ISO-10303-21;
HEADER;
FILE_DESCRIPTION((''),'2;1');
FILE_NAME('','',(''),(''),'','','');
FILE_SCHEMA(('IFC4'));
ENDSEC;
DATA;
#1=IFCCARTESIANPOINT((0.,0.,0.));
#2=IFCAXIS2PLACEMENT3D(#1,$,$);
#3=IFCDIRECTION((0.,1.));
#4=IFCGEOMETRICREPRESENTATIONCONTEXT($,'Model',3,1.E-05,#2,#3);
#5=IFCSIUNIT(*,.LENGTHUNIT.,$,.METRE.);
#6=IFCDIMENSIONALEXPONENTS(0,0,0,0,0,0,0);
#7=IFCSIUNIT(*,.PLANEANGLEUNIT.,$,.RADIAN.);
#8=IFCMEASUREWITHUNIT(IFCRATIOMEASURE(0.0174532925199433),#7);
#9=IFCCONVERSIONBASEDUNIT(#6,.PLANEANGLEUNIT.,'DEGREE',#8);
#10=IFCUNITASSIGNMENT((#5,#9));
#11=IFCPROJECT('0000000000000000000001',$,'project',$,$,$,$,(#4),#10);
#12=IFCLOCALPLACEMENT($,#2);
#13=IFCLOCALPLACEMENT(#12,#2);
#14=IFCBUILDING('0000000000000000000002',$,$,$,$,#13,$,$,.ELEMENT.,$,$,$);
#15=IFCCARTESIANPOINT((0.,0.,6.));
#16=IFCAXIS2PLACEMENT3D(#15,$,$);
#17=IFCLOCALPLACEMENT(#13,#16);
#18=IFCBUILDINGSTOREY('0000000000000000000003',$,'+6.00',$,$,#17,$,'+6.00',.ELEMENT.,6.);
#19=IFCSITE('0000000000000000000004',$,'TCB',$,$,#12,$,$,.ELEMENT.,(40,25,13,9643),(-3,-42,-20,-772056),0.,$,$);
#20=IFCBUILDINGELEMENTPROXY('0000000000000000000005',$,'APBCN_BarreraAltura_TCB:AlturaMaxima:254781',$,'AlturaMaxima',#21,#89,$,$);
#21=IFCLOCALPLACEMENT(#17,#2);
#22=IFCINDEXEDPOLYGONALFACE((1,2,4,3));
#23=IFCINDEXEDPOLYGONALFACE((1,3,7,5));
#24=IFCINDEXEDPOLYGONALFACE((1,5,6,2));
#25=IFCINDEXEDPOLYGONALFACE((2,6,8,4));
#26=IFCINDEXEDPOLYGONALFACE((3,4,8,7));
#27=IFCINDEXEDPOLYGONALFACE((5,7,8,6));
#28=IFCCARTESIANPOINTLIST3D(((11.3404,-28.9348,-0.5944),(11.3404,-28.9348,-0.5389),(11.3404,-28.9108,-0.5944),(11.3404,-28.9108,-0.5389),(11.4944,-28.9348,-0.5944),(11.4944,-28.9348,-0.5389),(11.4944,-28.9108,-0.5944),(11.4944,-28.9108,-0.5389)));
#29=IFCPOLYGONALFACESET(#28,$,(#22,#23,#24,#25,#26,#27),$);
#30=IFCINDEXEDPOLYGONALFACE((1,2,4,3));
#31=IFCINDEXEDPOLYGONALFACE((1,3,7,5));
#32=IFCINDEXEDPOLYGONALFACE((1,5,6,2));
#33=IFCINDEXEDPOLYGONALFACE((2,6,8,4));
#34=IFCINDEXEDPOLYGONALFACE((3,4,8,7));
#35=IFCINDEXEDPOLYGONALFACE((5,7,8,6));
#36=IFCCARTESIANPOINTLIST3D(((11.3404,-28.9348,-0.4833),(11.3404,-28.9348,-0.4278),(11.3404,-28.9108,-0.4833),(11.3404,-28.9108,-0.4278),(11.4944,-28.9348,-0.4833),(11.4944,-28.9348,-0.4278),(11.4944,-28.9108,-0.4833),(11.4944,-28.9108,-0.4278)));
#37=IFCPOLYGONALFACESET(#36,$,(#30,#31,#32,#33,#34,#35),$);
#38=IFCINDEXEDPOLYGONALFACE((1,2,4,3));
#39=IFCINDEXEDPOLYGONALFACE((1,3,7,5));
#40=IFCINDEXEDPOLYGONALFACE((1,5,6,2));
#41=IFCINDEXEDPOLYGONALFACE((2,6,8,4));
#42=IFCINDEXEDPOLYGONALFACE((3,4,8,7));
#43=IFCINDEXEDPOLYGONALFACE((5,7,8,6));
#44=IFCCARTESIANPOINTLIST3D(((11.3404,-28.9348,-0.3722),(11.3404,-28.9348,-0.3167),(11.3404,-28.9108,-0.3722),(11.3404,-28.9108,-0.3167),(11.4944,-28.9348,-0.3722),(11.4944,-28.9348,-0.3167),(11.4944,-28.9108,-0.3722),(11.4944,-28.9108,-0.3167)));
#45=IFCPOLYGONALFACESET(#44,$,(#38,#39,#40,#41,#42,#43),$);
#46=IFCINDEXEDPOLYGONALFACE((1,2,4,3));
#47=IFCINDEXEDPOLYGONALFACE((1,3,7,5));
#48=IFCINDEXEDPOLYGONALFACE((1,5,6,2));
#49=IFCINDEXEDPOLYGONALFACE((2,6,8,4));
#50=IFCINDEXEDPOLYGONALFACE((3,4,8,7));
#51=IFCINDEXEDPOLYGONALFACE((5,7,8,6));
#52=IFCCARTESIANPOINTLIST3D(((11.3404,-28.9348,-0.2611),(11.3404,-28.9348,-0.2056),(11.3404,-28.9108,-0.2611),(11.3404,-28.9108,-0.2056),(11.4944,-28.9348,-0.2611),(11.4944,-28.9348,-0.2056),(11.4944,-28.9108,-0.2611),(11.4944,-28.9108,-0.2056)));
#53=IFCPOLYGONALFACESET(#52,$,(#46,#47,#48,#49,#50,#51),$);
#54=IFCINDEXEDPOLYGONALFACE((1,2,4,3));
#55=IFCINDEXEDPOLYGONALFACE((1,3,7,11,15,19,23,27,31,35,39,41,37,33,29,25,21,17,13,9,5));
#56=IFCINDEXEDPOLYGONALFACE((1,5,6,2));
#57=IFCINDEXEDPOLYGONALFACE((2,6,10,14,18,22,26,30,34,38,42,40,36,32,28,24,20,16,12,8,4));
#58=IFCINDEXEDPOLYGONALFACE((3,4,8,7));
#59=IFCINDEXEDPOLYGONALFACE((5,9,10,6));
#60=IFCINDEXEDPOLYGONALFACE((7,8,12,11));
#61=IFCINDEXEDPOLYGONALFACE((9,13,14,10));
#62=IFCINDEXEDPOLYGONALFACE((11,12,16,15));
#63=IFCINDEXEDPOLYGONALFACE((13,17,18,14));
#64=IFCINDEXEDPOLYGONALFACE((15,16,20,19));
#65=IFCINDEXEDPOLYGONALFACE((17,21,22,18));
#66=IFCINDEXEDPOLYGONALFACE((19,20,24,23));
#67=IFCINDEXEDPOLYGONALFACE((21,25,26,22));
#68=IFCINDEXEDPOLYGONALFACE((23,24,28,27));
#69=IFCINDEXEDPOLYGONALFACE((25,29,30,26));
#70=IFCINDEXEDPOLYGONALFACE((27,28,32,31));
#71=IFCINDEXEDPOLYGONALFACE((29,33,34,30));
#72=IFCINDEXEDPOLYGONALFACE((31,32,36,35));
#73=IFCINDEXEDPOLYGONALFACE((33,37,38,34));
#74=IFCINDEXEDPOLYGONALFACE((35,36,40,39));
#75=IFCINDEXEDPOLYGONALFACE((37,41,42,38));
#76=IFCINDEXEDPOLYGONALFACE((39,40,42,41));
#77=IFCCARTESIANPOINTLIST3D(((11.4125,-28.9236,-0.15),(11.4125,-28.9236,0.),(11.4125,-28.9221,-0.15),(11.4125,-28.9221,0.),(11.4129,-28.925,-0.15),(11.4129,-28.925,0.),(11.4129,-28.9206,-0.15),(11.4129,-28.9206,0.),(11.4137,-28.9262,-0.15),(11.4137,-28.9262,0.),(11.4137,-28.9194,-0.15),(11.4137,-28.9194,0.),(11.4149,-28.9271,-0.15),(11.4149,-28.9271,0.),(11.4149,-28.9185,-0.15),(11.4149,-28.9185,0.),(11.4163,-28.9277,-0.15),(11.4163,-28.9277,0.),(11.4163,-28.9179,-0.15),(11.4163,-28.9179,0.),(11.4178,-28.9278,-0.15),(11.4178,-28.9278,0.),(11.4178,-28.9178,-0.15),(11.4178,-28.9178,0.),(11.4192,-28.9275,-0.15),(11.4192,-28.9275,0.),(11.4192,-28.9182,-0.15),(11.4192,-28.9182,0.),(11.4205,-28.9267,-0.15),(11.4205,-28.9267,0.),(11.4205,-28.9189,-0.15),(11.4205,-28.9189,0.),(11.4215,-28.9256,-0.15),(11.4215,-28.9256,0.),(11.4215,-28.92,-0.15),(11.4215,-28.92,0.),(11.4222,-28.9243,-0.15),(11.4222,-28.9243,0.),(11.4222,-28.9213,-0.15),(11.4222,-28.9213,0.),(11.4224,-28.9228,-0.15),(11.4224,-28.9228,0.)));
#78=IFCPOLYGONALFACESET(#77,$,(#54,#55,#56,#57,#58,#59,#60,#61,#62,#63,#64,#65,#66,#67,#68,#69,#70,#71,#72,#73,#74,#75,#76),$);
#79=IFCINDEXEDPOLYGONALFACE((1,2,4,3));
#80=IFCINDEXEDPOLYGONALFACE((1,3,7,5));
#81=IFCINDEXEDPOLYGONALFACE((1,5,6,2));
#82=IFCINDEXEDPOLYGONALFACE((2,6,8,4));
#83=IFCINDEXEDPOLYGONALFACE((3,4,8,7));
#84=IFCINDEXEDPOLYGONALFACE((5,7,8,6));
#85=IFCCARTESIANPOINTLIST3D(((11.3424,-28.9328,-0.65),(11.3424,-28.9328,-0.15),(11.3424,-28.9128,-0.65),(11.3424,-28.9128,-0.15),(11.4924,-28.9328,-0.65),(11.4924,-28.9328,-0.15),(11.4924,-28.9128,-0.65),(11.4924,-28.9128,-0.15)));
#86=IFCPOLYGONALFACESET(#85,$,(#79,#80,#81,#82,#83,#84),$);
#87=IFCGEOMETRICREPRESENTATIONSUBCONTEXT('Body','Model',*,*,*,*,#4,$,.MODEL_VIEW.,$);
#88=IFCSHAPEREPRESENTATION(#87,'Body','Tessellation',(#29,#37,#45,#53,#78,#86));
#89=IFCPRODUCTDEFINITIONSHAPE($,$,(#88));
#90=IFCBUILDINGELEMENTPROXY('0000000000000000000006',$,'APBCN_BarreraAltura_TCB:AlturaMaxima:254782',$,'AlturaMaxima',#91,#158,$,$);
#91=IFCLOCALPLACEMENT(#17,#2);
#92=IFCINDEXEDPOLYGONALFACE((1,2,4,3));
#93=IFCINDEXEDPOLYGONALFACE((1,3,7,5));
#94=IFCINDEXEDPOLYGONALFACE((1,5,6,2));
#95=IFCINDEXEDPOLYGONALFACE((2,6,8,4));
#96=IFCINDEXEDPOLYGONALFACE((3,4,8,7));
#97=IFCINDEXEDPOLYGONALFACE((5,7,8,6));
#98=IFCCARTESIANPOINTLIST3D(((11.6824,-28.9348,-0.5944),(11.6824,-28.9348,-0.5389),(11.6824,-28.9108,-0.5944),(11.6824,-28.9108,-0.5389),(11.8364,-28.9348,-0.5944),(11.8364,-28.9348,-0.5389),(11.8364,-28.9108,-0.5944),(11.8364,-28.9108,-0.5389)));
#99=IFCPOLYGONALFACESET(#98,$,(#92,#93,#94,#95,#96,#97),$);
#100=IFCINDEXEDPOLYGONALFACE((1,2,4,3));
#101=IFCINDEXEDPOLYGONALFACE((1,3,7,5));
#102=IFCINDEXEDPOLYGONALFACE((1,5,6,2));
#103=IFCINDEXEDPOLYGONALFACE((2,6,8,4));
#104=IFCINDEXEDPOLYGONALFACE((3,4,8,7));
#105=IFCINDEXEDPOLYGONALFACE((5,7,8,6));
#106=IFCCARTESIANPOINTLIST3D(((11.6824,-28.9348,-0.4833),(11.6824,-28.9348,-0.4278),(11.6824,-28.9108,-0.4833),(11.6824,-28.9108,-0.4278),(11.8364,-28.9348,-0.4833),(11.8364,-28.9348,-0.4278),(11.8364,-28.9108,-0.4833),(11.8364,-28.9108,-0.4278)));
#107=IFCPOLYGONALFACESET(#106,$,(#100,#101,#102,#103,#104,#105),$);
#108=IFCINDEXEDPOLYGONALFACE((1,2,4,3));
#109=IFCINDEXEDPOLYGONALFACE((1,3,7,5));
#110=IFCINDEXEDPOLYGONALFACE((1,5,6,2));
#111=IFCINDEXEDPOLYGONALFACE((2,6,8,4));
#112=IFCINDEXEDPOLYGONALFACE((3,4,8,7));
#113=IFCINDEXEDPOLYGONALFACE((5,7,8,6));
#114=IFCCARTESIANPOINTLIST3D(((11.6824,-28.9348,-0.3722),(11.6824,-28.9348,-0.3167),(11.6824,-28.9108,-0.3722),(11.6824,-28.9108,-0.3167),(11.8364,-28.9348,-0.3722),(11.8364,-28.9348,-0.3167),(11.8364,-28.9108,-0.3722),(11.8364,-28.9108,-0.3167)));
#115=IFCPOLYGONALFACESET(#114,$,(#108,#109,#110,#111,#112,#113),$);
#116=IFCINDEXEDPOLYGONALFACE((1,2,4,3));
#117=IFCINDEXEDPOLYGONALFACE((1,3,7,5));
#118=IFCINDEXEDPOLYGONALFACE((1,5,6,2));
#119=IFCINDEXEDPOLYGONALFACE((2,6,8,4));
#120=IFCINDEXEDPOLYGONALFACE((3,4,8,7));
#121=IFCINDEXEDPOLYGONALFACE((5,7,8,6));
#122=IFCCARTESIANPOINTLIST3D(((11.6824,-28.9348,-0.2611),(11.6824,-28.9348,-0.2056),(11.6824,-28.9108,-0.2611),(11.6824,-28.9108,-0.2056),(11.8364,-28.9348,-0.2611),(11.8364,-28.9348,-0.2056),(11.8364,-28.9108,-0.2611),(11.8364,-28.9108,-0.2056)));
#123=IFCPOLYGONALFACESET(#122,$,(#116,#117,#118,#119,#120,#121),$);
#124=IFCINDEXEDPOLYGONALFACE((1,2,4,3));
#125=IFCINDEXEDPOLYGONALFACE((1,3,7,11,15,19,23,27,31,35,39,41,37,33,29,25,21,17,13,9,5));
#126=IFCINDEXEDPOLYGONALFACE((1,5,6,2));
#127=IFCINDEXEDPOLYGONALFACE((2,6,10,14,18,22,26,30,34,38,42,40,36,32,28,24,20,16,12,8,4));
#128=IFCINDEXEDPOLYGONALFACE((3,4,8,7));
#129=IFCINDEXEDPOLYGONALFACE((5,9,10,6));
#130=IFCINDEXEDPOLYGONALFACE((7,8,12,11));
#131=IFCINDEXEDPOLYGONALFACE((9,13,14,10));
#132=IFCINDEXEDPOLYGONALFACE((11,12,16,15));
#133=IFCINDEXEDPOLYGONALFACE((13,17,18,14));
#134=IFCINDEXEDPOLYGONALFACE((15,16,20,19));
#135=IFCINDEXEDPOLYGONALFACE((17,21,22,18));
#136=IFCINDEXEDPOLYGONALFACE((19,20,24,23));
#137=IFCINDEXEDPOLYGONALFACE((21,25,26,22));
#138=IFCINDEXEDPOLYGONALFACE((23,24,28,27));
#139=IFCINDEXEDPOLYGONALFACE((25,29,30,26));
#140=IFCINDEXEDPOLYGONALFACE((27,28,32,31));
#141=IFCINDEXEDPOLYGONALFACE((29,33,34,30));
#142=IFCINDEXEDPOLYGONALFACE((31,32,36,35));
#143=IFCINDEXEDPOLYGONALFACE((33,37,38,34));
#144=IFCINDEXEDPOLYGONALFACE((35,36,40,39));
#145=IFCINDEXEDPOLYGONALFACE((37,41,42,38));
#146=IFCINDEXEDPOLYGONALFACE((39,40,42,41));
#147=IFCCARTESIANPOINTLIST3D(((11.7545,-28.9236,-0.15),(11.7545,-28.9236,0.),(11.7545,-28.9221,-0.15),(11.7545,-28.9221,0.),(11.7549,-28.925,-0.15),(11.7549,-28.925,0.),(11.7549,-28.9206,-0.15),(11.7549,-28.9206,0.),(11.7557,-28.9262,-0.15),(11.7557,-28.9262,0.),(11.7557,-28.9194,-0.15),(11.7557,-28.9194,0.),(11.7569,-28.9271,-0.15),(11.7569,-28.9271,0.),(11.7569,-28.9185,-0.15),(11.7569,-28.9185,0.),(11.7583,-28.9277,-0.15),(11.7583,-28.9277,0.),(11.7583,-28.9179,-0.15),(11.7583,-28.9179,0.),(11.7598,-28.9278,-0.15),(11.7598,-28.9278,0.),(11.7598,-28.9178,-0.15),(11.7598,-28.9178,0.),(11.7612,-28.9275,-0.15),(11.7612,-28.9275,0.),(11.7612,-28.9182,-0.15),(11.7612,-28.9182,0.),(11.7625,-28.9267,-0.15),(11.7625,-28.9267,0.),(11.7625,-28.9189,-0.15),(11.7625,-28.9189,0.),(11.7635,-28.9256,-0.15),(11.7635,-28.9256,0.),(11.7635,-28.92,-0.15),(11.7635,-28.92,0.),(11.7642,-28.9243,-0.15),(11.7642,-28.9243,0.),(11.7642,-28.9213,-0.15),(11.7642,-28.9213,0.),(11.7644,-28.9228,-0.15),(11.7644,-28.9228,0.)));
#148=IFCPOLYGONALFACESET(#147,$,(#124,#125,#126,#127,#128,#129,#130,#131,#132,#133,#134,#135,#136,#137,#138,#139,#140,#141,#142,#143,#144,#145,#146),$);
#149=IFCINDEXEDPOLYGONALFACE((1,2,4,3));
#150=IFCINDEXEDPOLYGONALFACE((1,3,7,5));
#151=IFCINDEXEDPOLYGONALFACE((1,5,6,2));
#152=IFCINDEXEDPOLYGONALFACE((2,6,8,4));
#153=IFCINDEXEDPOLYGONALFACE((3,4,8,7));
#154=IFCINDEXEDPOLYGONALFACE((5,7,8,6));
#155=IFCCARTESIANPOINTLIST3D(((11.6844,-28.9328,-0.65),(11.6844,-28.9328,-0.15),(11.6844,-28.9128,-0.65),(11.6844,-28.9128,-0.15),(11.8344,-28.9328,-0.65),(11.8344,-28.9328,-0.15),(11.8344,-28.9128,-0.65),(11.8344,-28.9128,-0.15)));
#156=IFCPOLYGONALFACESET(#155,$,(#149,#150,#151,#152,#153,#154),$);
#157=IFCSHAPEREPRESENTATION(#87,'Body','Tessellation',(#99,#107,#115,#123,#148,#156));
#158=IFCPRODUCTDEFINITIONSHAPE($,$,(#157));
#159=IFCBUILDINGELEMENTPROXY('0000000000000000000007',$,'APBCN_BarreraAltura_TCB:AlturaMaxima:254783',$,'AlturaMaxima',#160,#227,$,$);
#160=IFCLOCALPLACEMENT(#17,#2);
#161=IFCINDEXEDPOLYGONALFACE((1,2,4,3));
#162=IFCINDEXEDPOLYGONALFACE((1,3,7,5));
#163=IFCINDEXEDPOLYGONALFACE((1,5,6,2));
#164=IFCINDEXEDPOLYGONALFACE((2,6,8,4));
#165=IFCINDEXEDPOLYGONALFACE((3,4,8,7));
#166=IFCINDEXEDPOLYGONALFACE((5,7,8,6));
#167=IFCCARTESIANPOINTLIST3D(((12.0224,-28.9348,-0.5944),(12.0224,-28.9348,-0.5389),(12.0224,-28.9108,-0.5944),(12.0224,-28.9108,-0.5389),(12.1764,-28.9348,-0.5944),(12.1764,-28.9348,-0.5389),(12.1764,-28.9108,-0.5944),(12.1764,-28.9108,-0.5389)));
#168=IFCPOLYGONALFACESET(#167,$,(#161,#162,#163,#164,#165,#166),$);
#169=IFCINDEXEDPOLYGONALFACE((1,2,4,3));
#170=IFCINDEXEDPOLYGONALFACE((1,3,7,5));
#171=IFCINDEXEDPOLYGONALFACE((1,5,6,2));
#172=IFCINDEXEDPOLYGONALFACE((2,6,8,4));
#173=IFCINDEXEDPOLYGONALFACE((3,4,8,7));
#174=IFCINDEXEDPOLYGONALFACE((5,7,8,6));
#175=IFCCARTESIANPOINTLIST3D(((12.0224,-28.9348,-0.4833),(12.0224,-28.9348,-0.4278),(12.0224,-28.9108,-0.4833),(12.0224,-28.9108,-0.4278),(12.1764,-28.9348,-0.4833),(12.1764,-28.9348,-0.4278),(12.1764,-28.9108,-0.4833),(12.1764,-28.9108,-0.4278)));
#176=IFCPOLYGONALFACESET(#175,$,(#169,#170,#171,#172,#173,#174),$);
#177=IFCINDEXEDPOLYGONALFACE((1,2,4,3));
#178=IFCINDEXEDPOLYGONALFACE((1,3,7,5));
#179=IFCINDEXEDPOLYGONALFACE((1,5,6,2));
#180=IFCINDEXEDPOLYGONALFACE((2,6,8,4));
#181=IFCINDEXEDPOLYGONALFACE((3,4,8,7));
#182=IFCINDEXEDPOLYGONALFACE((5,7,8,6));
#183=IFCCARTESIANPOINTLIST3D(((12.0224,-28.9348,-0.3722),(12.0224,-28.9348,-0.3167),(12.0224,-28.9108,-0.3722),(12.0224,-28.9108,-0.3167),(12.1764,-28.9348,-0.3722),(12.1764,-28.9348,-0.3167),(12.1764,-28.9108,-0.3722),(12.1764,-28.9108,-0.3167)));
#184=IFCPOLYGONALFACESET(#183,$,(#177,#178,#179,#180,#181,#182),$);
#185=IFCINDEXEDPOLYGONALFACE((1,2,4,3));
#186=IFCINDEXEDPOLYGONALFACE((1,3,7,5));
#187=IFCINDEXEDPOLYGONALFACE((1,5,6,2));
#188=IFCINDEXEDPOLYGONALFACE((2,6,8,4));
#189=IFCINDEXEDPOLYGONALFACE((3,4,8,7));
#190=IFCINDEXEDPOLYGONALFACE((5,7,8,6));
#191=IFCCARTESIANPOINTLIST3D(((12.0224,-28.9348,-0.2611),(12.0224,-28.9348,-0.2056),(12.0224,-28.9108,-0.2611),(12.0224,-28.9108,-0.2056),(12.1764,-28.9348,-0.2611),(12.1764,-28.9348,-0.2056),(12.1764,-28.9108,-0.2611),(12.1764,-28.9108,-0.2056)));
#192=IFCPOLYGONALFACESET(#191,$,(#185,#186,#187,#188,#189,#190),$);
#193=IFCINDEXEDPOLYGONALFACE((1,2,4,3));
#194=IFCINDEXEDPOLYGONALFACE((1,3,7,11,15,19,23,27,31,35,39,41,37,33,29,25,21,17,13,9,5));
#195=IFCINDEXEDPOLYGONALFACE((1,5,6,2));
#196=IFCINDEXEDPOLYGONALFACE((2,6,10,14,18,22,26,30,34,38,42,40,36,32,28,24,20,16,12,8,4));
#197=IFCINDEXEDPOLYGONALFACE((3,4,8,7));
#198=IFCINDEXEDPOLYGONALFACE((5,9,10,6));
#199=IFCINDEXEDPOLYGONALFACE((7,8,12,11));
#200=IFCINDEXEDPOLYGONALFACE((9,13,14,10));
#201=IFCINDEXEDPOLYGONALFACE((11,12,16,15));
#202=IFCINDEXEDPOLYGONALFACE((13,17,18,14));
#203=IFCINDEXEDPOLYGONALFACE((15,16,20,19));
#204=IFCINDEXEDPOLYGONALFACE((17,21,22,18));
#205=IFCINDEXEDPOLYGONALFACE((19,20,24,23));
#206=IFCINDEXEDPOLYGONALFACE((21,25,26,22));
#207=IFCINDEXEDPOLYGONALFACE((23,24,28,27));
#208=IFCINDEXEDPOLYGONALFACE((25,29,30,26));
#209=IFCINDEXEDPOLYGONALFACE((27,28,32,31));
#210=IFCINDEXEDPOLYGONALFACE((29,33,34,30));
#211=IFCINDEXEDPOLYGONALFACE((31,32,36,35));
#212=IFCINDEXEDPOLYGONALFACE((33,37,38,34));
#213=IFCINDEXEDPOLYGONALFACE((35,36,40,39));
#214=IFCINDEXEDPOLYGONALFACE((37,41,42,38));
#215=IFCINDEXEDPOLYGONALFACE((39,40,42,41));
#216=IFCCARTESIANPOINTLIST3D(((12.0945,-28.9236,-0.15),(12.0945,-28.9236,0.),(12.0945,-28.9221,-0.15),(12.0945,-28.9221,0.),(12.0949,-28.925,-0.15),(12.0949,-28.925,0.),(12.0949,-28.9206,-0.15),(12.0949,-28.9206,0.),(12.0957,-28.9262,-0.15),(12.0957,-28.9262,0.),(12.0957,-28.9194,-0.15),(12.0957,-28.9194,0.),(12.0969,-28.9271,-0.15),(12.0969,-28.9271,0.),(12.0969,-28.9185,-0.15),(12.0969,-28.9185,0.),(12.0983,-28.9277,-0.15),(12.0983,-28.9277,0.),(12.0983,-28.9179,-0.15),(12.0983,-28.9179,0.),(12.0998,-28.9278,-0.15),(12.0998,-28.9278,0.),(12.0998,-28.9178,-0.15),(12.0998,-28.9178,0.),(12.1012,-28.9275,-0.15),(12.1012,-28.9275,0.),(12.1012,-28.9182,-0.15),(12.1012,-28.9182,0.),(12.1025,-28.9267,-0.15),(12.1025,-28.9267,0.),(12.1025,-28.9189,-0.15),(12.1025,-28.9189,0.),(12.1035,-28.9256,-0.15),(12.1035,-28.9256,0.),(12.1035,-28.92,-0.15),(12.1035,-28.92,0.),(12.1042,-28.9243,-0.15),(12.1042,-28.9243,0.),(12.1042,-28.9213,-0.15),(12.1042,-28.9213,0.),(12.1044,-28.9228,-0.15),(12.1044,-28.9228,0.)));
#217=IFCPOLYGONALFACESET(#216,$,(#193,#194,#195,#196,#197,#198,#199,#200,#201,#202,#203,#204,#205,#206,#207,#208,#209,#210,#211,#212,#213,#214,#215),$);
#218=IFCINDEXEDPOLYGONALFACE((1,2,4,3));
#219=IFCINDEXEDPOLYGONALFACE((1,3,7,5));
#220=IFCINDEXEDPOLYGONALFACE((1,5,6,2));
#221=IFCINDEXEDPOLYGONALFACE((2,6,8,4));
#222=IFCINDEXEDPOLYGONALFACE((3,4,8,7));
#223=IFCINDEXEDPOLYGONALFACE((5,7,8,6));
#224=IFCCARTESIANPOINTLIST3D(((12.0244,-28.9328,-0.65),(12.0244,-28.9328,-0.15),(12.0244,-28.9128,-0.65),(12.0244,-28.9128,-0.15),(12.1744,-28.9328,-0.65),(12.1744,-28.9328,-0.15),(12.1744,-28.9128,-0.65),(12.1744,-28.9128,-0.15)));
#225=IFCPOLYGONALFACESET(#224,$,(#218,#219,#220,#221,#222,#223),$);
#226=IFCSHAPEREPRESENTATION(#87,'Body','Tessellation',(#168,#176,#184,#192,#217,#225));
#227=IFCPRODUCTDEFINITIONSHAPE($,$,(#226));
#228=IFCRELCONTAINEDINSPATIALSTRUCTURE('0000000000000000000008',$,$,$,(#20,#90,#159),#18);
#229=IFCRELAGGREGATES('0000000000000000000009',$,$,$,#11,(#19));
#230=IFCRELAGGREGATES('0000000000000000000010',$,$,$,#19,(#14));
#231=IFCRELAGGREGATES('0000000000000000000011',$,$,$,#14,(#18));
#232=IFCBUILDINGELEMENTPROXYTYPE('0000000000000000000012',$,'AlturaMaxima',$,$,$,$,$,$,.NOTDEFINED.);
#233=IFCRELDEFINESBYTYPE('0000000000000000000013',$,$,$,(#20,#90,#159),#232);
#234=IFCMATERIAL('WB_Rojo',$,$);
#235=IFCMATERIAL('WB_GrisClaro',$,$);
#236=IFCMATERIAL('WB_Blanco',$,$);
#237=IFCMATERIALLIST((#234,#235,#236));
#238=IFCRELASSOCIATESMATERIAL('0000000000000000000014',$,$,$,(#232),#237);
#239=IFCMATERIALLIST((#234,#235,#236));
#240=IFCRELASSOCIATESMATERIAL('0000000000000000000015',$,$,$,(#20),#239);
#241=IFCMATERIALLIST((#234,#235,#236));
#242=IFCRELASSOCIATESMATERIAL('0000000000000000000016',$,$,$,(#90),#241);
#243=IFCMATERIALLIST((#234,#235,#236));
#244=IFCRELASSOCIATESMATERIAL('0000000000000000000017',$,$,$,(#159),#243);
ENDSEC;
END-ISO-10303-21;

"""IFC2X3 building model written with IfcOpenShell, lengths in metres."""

from ifc_helpers import new_model, entity, si_unit, converted_unit, direction, frame, frame_2d, origin, origin_2d_with_axis, place, context, subcontext, project, spatial, rectangle, circle, extrude, source, transform, mapped, material, material_list, type_object, type_shapes, element, save


model = new_model("IFC2X3")

# Units and contexts
model_context = context("Model", 3, precision=1e-05, world=origin(), true_north=direction((0.0, 1.0)))
body_context = subcontext(model_context, "Body", "Model", "MODEL_VIEW")
ifc_project = project(units=[si_unit("LENGTHUNIT", "METRE"), converted_unit("PLANEANGLEUNIT", "DEGREE", entity("IfcRatioMeasure", 0.0174532925199433), si_unit("PLANEANGLEUNIT", "RADIAN"), dimensions=[0, 0, 0, 0, 0, 0, 0])], contexts=[model_context])

# Site, building, storey
site_placement = place(None, origin())
site = spatial("IfcSite", under=ifc_project, at=site_placement, Name="TCB", CompositionType="ELEMENT", RefLatitude=(40, 25, 13, 9643), RefLongitude=(-3, -42, -20, -772056), RefElevation=0.0)
building_placement = place(site_placement, origin())
building = spatial("IfcBuilding", under=site, at=building_placement, CompositionType="ELEMENT")
storey_placement = place(building_placement, frame((0.0, 0.0, 6.0)))
storey = spatial("IfcBuildingStorey", under=building, at=storey_placement, Name="+6.00", LongName="+6.00", CompositionType="ELEMENT", Elevation=6.0)

# Building element proxies
ifc_material_1 = material(Name="WB_Rojo")
ifc_material_2 = material(Name="WB_GrisClaro")
ifc_material_3 = material(Name="WB_Blanco")
ifc_material_list_1 = material_list([ifc_material_1, ifc_material_2, ifc_material_3])
building_element_proxy_type = type_object("IfcBuildingElementProxyType", Name="AlturaMaxima", PredefinedType="NOTDEFINED", material=ifc_material_list_1)
shared_shape = source(origin(), body_context, "Body", "SweptSolid", [
    extrude(rectangle(XDim=0.154, YDim=0.024, at=frame_2d((0.0, 0.0), x_axis=(1.0, 0.0))), frame((0.0, 0.0, -0.5944), z_axis=(0.0, 0.0, 1.0), x_axis=(-1.0, 0.0, 0.0)), (0.0, 0.0, 1.0), 0.0556),
    extrude(rectangle(XDim=0.154, YDim=0.024, at=frame_2d((0.0, 0.0), x_axis=(1.0, 0.0))), frame((0.0, 0.0, -0.4833), z_axis=(0.0, 0.0, 1.0), x_axis=(-1.0, 0.0, 0.0)), (0.0, 0.0, 1.0), 0.0556),
    extrude(rectangle(XDim=0.154, YDim=0.024, at=frame_2d((0.0, 0.0), x_axis=(1.0, 0.0))), frame((0.0, 0.0, -0.3722), z_axis=(0.0, 0.0, 1.0), x_axis=(-1.0, 0.0, 0.0)), (0.0, 0.0, 1.0), 0.0556),
    extrude(rectangle(XDim=0.154, YDim=0.024, at=frame_2d((0.0, 0.0), x_axis=(1.0, 0.0))), frame((0.0, 0.0, -0.2611), z_axis=(0.0, 0.0, 1.0), x_axis=(-1.0, 0.0, 0.0)), (0.0, 0.0, 1.0), 0.0556),
    extrude(circle(Radius=0.005, at=frame_2d((0.0, 0.0), x_axis=(1.0, 0.0))), frame((0.0, 0.0, -0.15)), (0.0, 0.0, 1.0), 0.15),
    extrude(rectangle(XDim=0.02, YDim=0.15, at=origin_2d_with_axis()), frame((0.0, 0.0, -0.65), z_axis=(0.0, 0.0, 1.0), x_axis=(0.0, 1.0, 0.0)), (0.0, 0.0, 1.0), 0.5),
])
type_shapes(building_element_proxy_type, [shared_shape])
ifc_material_list_2 = material_list([ifc_material_1, ifc_material_2, ifc_material_3])
proxy_1_placement = place(storey_placement, frame((11.4174, -28.9228, 0.0)))
element("IfcBuildingElementProxy", 1, at=proxy_1_placement, inside=storey, type_object=building_element_proxy_type, material=ifc_material_list_2, Name="APBCN_BarreraAltura_TCB:AlturaMaxima:254781", ObjectType="AlturaMaxima", context=body_context, shape_type="MappedRepresentation", body=[
    mapped(shared_shape, transform((0.0, 0.0, 0.0), scale=1.0)),
])
ifc_material_list_3 = material_list([ifc_material_1, ifc_material_2, ifc_material_3])
proxy_2_placement = place(storey_placement, frame((11.7594, -28.9228, 0.0)))
element("IfcBuildingElementProxy", 2, at=proxy_2_placement, inside=storey, type_object=building_element_proxy_type, material=ifc_material_list_3, Name="APBCN_BarreraAltura_TCB:AlturaMaxima:254782", ObjectType="AlturaMaxima", context=body_context, shape_type="MappedRepresentation", body=[
    mapped(shared_shape, transform((0.0, 0.0, 0.0), scale=1.0)),
])
ifc_material_list_4 = material_list([ifc_material_1, ifc_material_2, ifc_material_3])
proxy_3_placement = place(storey_placement, frame((12.0994, -28.9228, 0.0)))
element("IfcBuildingElementProxy", 3, at=proxy_3_placement, inside=storey, type_object=building_element_proxy_type, material=ifc_material_list_4, Name="APBCN_BarreraAltura_TCB:AlturaMaxima:254783", ObjectType="AlturaMaxima", context=body_context, shape_type="MappedRepresentation", body=[
    mapped(shared_shape, transform((0.0, 0.0, 0.0), scale=1.0)),
])

save(model, "model.ifc")
